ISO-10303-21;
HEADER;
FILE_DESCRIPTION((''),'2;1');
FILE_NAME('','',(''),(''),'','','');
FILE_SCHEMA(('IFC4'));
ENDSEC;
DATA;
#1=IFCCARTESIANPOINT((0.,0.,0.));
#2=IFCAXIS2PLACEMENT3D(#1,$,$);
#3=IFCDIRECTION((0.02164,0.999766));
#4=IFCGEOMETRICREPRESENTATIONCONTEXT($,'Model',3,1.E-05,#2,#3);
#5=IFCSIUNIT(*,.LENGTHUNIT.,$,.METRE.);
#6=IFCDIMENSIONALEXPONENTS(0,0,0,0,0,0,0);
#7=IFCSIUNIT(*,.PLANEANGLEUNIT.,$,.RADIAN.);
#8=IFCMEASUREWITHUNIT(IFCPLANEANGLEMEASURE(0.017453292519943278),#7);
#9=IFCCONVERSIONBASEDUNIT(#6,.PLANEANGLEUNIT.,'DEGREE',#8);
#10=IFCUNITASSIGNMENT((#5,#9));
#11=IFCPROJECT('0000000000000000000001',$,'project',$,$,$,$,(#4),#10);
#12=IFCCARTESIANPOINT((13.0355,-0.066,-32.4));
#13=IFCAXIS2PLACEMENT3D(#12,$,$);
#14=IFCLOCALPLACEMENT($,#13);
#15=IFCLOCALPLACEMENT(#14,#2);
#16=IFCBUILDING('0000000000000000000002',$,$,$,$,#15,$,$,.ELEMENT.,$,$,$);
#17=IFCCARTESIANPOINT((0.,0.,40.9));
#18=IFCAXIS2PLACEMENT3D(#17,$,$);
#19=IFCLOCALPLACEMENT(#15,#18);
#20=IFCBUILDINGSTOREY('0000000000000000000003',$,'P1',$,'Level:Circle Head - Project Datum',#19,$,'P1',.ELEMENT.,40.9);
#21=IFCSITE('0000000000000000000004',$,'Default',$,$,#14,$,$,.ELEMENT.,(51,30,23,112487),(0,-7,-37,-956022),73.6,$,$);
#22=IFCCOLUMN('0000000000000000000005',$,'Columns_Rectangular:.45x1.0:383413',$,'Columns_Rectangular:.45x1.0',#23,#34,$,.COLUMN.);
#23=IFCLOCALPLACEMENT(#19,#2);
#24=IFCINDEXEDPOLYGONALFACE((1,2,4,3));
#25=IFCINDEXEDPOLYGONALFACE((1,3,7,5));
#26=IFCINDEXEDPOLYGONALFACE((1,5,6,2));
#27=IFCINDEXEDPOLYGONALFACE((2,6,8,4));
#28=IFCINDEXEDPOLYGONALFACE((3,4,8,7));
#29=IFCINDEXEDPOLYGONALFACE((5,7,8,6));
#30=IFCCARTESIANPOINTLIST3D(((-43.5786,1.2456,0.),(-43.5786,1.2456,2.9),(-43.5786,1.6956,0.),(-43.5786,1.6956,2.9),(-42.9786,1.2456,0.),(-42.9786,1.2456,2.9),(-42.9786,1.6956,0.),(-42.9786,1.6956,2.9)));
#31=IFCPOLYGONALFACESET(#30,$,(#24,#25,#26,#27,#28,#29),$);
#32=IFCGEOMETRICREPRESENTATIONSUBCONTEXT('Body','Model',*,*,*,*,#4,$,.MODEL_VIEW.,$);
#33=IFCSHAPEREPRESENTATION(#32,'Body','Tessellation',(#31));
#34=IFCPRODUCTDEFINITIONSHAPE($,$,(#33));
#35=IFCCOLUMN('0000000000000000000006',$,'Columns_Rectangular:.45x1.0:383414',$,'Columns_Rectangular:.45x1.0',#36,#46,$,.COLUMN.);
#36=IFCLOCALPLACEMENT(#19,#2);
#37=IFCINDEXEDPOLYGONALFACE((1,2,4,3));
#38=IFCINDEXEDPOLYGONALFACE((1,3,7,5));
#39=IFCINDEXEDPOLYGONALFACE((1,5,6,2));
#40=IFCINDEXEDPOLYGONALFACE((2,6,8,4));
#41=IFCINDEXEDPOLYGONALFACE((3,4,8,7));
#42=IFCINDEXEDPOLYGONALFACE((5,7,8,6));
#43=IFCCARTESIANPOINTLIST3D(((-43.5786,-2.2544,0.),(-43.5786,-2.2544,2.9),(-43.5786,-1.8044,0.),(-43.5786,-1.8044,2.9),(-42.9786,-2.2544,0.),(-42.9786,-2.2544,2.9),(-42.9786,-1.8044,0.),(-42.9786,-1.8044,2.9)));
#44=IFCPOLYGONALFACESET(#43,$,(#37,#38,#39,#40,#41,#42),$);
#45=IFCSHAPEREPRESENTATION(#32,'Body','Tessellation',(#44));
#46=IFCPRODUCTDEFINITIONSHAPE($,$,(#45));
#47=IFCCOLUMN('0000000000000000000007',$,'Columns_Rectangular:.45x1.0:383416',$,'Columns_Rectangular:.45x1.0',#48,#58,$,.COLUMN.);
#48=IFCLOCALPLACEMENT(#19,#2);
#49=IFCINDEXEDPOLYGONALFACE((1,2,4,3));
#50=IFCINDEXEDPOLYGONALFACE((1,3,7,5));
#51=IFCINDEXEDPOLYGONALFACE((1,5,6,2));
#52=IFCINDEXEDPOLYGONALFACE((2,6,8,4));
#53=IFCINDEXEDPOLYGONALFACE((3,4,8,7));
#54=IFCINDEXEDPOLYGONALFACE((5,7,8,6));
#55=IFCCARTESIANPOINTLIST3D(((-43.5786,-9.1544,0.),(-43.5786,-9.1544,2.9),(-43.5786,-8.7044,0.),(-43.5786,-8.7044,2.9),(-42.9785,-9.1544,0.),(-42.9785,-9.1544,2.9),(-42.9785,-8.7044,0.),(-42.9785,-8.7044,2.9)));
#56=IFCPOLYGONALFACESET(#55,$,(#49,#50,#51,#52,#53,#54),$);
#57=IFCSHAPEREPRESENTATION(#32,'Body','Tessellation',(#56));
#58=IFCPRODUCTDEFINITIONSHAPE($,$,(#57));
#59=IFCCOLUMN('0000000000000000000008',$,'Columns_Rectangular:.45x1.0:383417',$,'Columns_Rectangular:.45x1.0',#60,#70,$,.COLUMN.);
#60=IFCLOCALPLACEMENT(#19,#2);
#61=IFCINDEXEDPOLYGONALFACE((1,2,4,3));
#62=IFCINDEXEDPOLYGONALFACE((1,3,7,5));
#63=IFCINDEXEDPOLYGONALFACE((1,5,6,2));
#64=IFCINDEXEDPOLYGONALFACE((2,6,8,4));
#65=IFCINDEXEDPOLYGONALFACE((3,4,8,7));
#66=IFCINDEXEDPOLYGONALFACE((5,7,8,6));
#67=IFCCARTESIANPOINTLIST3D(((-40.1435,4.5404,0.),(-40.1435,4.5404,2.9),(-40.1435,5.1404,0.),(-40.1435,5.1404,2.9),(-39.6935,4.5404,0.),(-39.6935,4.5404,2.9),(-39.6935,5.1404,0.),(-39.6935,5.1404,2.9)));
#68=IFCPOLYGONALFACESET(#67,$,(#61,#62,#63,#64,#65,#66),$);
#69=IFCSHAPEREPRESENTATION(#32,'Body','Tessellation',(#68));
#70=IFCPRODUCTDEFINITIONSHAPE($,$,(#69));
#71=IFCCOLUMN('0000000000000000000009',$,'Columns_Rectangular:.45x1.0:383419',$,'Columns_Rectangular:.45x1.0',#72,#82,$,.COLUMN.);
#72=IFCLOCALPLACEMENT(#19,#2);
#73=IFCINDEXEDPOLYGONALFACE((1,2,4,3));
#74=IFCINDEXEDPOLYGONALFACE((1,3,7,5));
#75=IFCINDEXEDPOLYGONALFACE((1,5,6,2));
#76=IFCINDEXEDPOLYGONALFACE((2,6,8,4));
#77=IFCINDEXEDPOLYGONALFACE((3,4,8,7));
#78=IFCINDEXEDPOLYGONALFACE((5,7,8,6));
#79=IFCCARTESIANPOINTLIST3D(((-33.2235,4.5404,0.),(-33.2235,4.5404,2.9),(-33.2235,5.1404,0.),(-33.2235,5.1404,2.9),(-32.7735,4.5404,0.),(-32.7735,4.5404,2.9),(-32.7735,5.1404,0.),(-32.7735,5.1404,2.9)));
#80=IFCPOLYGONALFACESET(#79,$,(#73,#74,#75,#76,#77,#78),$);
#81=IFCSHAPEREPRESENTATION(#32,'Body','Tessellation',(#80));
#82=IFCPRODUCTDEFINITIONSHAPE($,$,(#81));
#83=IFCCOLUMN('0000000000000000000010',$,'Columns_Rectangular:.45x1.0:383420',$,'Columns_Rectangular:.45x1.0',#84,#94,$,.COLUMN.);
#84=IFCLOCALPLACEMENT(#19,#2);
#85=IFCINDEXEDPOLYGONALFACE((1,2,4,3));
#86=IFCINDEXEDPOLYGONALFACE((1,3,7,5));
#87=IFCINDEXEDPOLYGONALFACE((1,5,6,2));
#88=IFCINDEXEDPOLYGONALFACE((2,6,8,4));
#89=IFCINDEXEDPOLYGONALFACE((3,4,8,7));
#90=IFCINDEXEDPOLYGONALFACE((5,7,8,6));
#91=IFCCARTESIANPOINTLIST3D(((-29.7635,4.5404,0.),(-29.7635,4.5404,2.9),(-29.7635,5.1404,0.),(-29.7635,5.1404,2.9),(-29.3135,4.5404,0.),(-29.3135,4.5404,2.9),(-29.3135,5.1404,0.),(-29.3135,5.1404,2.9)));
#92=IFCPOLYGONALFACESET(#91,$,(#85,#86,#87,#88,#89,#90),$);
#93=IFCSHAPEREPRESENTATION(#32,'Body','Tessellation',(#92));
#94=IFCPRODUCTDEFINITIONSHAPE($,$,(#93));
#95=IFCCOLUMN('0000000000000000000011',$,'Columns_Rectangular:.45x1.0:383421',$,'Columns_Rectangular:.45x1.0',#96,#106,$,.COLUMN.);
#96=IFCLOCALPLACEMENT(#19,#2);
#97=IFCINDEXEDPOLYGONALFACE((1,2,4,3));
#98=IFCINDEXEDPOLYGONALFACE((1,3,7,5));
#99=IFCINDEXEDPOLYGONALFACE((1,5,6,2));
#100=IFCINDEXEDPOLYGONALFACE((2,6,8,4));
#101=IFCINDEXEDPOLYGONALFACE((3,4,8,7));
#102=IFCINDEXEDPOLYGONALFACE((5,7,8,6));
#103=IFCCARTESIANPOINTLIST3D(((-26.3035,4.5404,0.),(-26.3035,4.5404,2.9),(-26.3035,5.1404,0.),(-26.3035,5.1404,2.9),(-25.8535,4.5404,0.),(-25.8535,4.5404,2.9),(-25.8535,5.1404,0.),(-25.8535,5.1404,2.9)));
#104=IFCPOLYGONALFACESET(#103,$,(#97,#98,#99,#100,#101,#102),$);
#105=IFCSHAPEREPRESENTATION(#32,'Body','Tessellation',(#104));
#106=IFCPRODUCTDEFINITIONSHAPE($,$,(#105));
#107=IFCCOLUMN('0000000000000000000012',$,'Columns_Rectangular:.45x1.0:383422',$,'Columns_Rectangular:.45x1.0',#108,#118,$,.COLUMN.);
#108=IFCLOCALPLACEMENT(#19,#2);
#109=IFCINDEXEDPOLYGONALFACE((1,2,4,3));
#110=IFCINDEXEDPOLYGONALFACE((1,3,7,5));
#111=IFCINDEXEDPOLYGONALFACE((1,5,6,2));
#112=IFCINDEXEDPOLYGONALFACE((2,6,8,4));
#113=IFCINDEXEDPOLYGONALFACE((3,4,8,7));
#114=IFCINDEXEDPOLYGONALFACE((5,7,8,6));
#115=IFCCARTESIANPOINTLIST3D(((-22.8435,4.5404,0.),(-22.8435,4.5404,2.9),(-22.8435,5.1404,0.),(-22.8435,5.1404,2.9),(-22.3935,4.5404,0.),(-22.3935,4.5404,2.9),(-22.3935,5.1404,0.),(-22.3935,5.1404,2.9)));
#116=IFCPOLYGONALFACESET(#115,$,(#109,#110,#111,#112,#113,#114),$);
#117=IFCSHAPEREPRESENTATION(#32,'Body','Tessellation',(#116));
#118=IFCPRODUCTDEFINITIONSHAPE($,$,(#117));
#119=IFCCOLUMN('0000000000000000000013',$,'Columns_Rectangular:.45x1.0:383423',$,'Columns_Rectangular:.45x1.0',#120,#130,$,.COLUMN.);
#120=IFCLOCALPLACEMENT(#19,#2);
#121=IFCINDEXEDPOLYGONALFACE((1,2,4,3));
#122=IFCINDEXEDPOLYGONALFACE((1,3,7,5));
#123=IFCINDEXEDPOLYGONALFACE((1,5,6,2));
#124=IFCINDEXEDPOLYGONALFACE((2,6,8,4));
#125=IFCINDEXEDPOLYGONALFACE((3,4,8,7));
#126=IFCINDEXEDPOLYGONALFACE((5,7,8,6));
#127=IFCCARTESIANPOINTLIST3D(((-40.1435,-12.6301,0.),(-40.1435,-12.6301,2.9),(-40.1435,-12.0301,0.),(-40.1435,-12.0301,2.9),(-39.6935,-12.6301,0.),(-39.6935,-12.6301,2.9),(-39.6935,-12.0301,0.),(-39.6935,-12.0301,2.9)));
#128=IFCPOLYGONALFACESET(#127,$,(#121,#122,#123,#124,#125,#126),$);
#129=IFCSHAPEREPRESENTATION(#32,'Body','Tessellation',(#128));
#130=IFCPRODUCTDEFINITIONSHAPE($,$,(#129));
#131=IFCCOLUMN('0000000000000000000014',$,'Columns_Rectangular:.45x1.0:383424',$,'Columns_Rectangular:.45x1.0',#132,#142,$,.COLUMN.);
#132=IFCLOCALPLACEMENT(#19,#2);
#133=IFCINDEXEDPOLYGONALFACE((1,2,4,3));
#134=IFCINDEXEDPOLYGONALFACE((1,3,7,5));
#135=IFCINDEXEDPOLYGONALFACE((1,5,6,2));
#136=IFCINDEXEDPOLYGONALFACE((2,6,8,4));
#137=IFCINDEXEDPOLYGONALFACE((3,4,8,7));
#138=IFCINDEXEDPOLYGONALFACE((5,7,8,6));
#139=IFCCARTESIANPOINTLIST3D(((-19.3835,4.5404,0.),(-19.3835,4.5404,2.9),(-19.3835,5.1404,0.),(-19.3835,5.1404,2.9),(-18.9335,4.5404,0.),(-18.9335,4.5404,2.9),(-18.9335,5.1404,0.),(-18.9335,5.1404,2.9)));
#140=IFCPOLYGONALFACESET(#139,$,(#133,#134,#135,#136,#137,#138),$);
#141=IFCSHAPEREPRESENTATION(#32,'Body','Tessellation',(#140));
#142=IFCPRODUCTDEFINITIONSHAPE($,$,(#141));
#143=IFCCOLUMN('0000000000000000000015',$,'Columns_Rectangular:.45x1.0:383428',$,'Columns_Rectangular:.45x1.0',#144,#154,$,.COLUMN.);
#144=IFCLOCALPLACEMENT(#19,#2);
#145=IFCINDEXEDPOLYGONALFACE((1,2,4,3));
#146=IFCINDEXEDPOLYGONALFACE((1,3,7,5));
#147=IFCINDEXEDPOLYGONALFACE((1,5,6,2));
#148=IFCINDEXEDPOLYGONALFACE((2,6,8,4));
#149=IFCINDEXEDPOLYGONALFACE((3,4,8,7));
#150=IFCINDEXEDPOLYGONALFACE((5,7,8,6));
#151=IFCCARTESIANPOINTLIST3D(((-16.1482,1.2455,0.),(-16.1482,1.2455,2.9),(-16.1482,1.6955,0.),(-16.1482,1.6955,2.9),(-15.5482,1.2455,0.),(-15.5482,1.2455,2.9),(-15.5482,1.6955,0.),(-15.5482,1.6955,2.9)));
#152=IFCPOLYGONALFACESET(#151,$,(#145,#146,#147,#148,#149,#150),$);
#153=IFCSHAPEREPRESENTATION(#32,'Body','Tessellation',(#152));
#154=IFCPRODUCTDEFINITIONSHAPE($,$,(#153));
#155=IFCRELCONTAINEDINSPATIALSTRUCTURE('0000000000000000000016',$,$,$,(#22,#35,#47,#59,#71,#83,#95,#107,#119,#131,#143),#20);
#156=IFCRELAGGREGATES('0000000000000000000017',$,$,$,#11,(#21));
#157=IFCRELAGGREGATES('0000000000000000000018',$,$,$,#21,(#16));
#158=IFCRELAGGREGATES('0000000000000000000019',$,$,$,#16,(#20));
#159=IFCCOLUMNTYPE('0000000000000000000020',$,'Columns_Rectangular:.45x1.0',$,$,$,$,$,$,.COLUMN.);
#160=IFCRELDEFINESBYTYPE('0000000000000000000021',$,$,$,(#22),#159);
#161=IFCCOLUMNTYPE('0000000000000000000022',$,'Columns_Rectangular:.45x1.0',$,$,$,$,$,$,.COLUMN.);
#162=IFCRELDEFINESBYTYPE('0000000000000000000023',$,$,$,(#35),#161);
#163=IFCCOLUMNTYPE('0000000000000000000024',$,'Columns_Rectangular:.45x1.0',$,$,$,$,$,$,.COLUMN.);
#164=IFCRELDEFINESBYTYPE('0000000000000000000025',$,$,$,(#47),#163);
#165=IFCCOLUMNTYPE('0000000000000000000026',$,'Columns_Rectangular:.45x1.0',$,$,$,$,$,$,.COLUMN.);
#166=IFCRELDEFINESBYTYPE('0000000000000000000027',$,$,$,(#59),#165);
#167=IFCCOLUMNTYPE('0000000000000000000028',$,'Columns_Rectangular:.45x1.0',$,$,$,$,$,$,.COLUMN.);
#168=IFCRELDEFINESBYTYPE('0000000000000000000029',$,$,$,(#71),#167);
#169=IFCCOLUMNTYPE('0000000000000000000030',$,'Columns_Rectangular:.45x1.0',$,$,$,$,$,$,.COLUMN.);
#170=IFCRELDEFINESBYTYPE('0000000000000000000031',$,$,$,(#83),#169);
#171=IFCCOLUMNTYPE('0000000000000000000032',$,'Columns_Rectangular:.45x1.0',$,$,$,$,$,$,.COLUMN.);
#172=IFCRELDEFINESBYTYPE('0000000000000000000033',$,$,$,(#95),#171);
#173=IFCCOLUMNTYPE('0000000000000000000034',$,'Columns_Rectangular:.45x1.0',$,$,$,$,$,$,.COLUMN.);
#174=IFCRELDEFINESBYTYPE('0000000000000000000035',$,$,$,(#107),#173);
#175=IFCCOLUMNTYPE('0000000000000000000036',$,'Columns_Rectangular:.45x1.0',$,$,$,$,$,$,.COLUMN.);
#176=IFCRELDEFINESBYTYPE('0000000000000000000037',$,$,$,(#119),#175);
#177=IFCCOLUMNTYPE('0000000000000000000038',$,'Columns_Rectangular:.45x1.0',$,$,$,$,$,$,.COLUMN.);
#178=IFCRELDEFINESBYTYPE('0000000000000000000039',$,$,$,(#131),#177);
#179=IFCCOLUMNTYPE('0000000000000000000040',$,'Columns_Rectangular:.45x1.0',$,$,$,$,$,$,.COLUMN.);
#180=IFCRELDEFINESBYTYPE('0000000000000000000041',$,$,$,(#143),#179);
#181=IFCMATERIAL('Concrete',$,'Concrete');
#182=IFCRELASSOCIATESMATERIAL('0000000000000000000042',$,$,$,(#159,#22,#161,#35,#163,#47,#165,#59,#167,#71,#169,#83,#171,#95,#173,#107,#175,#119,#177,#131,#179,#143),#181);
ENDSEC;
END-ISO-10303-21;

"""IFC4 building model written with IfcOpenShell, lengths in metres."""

from ifc_helpers import new_model, entity, si_unit, converted_unit, direction, frame, origin, place, context, subcontext, project, spatial, indexed_curve, outline, extrude, source, transform, mapped, material, type_object, type_shapes, element, save


model = new_model("IFC4")

# Units and contexts
model_context = context("Model", 3, precision=1e-05, world=origin(), true_north=direction((0.02164, 0.999766)))
body_context = subcontext(model_context, "Body", "Model", "MODEL_VIEW")
ifc_project = project(units=[si_unit("LENGTHUNIT", "METRE"), converted_unit("PLANEANGLEUNIT", "DEGREE", entity("IfcPlaneAngleMeasure", 0.017453292519943278), si_unit("PLANEANGLEUNIT", "RADIAN"), dimensions=[0, 0, 0, 0, 0, 0, 0])], contexts=[model_context])

# Site, building, storey
site_placement = place(None, frame((13.0355, -0.066, -32.4)))
site = spatial("IfcSite", under=ifc_project, at=site_placement, Name="Default", CompositionType="ELEMENT", RefLatitude=(51, 30, 23, 112487), RefLongitude=(0, -7, -37, -956022), RefElevation=73.6)
building_placement = place(site_placement, origin())
building = spatial("IfcBuilding", under=site, at=building_placement, CompositionType="ELEMENT")
storey_placement = place(building_placement, frame((0.0, 0.0, 40.9)))
storey = spatial("IfcBuildingStorey", under=building, at=storey_placement, Name="P1", ObjectType="Level:Circle Head - Project Datum", LongName="P1", CompositionType="ELEMENT", Elevation=40.9)

# Columns
ifc_material = material(Name="Concrete", Category="Concrete")
column_type_1 = type_object("IfcColumnType", Name="Columns_Rectangular:.45x1.0", PredefinedType="COLUMN", material=ifc_material)
shared_shape_1 = source(origin(), body_context, "Body", "SweptSolid", [
    extrude(outline(indexed_curve([(-0.3, -0.225), (0.3, -0.225), (0.3, 0.225), (-0.3, 0.225), (-0.3, -0.225)], self_intersect=False)), frame((-43.2786, 1.4706, 40.9)), (0.0, 0.0, 1.0), 2.9),
])
type_shapes(column_type_1, [shared_shape_1])
column_1_placement = place(storey_placement, frame((0.0, 0.0, -40.9)))
element("IfcColumn", 1, at=column_1_placement, inside=storey, type_object=column_type_1, material=ifc_material, Name="Columns_Rectangular:.45x1.0:383413", ObjectType="Columns_Rectangular:.45x1.0", PredefinedType="COLUMN", context=body_context, shape_type="MappedRepresentation", body=[
    mapped(shared_shape_1, transform((0.0, 0.0, 0.0), scale=1.0)),
])
column_type_2 = type_object("IfcColumnType", Name="Columns_Rectangular:.45x1.0", PredefinedType="COLUMN", material=ifc_material)
shared_shape_2 = source(origin(), body_context, "Body", "SweptSolid", [
    extrude(outline(indexed_curve([(-0.3, -0.225), (0.3, -0.225), (0.3, 0.225), (-0.3, 0.225), (-0.3, -0.225)], self_intersect=False)), frame((-43.2786, -2.0294, 40.9)), (0.0, 0.0, 1.0), 2.9),
])
type_shapes(column_type_2, [shared_shape_2])
column_2_placement = place(storey_placement, frame((0.0, 0.0, -40.9)))
element("IfcColumn", 2, at=column_2_placement, inside=storey, type_object=column_type_2, material=ifc_material, Name="Columns_Rectangular:.45x1.0:383414", ObjectType="Columns_Rectangular:.45x1.0", PredefinedType="COLUMN", context=body_context, shape_type="MappedRepresentation", body=[
    mapped(shared_shape_2, transform((0.0, 0.0, 0.0), scale=1.0)),
])
column_type_3 = type_object("IfcColumnType", Name="Columns_Rectangular:.45x1.0", PredefinedType="COLUMN", material=ifc_material)
shared_shape_3 = source(origin(), body_context, "Body", "SweptSolid", [
    extrude(outline(indexed_curve([(-0.3, -0.225), (0.3, -0.225), (0.3, 0.225), (-0.3, 0.225), (-0.3, -0.225)], self_intersect=False)), frame((-43.2785, -8.9294, 40.9)), (0.0, 0.0, 1.0), 2.9),
])
type_shapes(column_type_3, [shared_shape_3])
column_3_placement = place(storey_placement, frame((0.0, 0.0, -40.9)))
element("IfcColumn", 3, at=column_3_placement, inside=storey, type_object=column_type_3, material=ifc_material, Name="Columns_Rectangular:.45x1.0:383416", ObjectType="Columns_Rectangular:.45x1.0", PredefinedType="COLUMN", context=body_context, shape_type="MappedRepresentation", body=[
    mapped(shared_shape_3, transform((0.0, 0.0, 0.0), scale=1.0)),
])
column_type_4 = type_object("IfcColumnType", Name="Columns_Rectangular:.45x1.0", PredefinedType="COLUMN", material=ifc_material)
shared_shape_4 = source(origin(), body_context, "Body", "SweptSolid", [
    extrude(outline(indexed_curve([(-0.3, -0.225), (0.3, -0.225), (0.3, 0.225), (-0.3, 0.225), (-0.3, -0.225)], self_intersect=False)), frame((-39.9185, 4.8404, 40.9), z_axis=(0.0, 0.0, 1.0), x_axis=(0.0, -1.0, 0.0)), (0.0, 0.0, 1.0), 2.9),
])
type_shapes(column_type_4, [shared_shape_4])
column_4_placement = place(storey_placement, frame((0.0, 0.0, -40.9)))
element("IfcColumn", 4, at=column_4_placement, inside=storey, type_object=column_type_4, material=ifc_material, Name="Columns_Rectangular:.45x1.0:383417", ObjectType="Columns_Rectangular:.45x1.0", PredefinedType="COLUMN", context=body_context, shape_type="MappedRepresentation", body=[
    mapped(shared_shape_4, transform((0.0, 0.0, 0.0), scale=1.0)),
])
column_type_5 = type_object("IfcColumnType", Name="Columns_Rectangular:.45x1.0", PredefinedType="COLUMN", material=ifc_material)
shared_shape_5 = source(origin(), body_context, "Body", "SweptSolid", [
    extrude(outline(indexed_curve([(-0.3, -0.225), (0.3, -0.225), (0.3, 0.225), (-0.3, 0.225), (-0.3, -0.225)], self_intersect=False)), frame((-32.9985, 4.8404, 40.9), z_axis=(0.0, 0.0, 1.0), x_axis=(0.0, -1.0, 0.0)), (0.0, 0.0, 1.0), 2.9),
])
type_shapes(column_type_5, [shared_shape_5])
column_5_placement = place(storey_placement, frame((0.0, 0.0, -40.9)))
element("IfcColumn", 5, at=column_5_placement, inside=storey, type_object=column_type_5, material=ifc_material, Name="Columns_Rectangular:.45x1.0:383419", ObjectType="Columns_Rectangular:.45x1.0", PredefinedType="COLUMN", context=body_context, shape_type="MappedRepresentation", body=[
    mapped(shared_shape_5, transform((0.0, 0.0, 0.0), scale=1.0)),
])
column_type_6 = type_object("IfcColumnType", Name="Columns_Rectangular:.45x1.0", PredefinedType="COLUMN", material=ifc_material)
shared_shape_6 = source(origin(), body_context, "Body", "SweptSolid", [
    extrude(outline(indexed_curve([(-0.3, -0.225), (0.3, -0.225), (0.3, 0.225), (-0.3, 0.225), (-0.3, -0.225)], self_intersect=False)), frame((-29.5385, 4.8404, 40.9), z_axis=(0.0, 0.0, 1.0), x_axis=(0.0, -1.0, 0.0)), (0.0, 0.0, 1.0), 2.9),
])
type_shapes(column_type_6, [shared_shape_6])
column_6_placement = place(storey_placement, frame((0.0, 0.0, -40.9)))
element("IfcColumn", 6, at=column_6_placement, inside=storey, type_object=column_type_6, material=ifc_material, Name="Columns_Rectangular:.45x1.0:383420", ObjectType="Columns_Rectangular:.45x1.0", PredefinedType="COLUMN", context=body_context, shape_type="MappedRepresentation", body=[
    mapped(shared_shape_6, transform((0.0, 0.0, 0.0), scale=1.0)),
])
column_type_7 = type_object("IfcColumnType", Name="Columns_Rectangular:.45x1.0", PredefinedType="COLUMN", material=ifc_material)
shared_shape_7 = source(origin(), body_context, "Body", "SweptSolid", [
    extrude(outline(indexed_curve([(-0.3, -0.225), (0.3, -0.225), (0.3, 0.225), (-0.3, 0.225), (-0.3, -0.225)], self_intersect=False)), frame((-26.0785, 4.8404, 40.9), z_axis=(0.0, 0.0, 1.0), x_axis=(0.0, -1.0, 0.0)), (0.0, 0.0, 1.0), 2.9),
])
type_shapes(column_type_7, [shared_shape_7])
column_7_placement = place(storey_placement, frame((0.0, 0.0, -40.9)))
element("IfcColumn", 7, at=column_7_placement, inside=storey, type_object=column_type_7, material=ifc_material, Name="Columns_Rectangular:.45x1.0:383421", ObjectType="Columns_Rectangular:.45x1.0", PredefinedType="COLUMN", context=body_context, shape_type="MappedRepresentation", body=[
    mapped(shared_shape_7, transform((0.0, 0.0, 0.0), scale=1.0)),
])
column_type_8 = type_object("IfcColumnType", Name="Columns_Rectangular:.45x1.0", PredefinedType="COLUMN", material=ifc_material)
shared_shape_8 = source(origin(), body_context, "Body", "SweptSolid", [
    extrude(outline(indexed_curve([(-0.3, -0.225), (0.3, -0.225), (0.3, 0.225), (-0.3, 0.225), (-0.3, -0.225)], self_intersect=False)), frame((-22.6185, 4.8404, 40.9), z_axis=(0.0, 0.0, 1.0), x_axis=(0.0, -1.0, 0.0)), (0.0, 0.0, 1.0), 2.9),
])
type_shapes(column_type_8, [shared_shape_8])
column_8_placement = place(storey_placement, frame((0.0, 0.0, -40.9)))
element("IfcColumn", 8, at=column_8_placement, inside=storey, type_object=column_type_8, material=ifc_material, Name="Columns_Rectangular:.45x1.0:383422", ObjectType="Columns_Rectangular:.45x1.0", PredefinedType="COLUMN", context=body_context, shape_type="MappedRepresentation", body=[
    mapped(shared_shape_8, transform((0.0, 0.0, 0.0), scale=1.0)),
])
column_type_9 = type_object("IfcColumnType", Name="Columns_Rectangular:.45x1.0", PredefinedType="COLUMN", material=ifc_material)
shared_shape_9 = source(origin(), body_context, "Body", "SweptSolid", [
    extrude(outline(indexed_curve([(-0.3, -0.225), (0.3, -0.225), (0.3, 0.225), (-0.3, 0.225), (-0.3, -0.225)], self_intersect=False)), frame((-39.9185, -12.3301, 40.9), z_axis=(0.0, 0.0, 1.0), x_axis=(0.000011, 1.0, 0.0)), (0.0, 0.0, 1.0), 2.9),
])
type_shapes(column_type_9, [shared_shape_9])
column_9_placement = place(storey_placement, frame((0.0, 0.0, -40.9)))
element("IfcColumn", 9, at=column_9_placement, inside=storey, type_object=column_type_9, material=ifc_material, Name="Columns_Rectangular:.45x1.0:383423", ObjectType="Columns_Rectangular:.45x1.0", PredefinedType="COLUMN", context=body_context, shape_type="MappedRepresentation", body=[
    mapped(shared_shape_9, transform((0.0, 0.0, 0.0), scale=1.0)),
])
column_type_10 = type_object("IfcColumnType", Name="Columns_Rectangular:.45x1.0", PredefinedType="COLUMN", material=ifc_material)
shared_shape_10 = source(origin(), body_context, "Body", "SweptSolid", [
    extrude(outline(indexed_curve([(-0.3, -0.225), (0.3, -0.225), (0.3, 0.225), (-0.3, 0.225), (-0.3, -0.225)], self_intersect=False)), frame((-19.1585, 4.8404, 40.9), z_axis=(0.0, 0.0, 1.0), x_axis=(0.0, -1.0, 0.0)), (0.0, 0.0, 1.0), 2.9),
])
type_shapes(column_type_10, [shared_shape_10])
column_10_placement = place(storey_placement, frame((0.0, 0.0, -40.9)))
element("IfcColumn", 10, at=column_10_placement, inside=storey, type_object=column_type_10, material=ifc_material, Name="Columns_Rectangular:.45x1.0:383424", ObjectType="Columns_Rectangular:.45x1.0", PredefinedType="COLUMN", context=body_context, shape_type="MappedRepresentation", body=[
    mapped(shared_shape_10, transform((0.0, 0.0, 0.0), scale=1.0)),
])
column_type_11 = type_object("IfcColumnType", Name="Columns_Rectangular:.45x1.0", PredefinedType="COLUMN", material=ifc_material)
shared_shape_11 = source(origin(), body_context, "Body", "SweptSolid", [
    extrude(outline(indexed_curve([(-0.3, -0.225), (0.3, -0.225), (0.3, 0.225), (-0.3, 0.225), (-0.3, -0.225)], self_intersect=False)), frame((-15.8482, 1.4705, 40.9), z_axis=(0.0, 0.0, 1.0), x_axis=(-1.0, 0.0, 0.0)), (0.0, 0.0, 1.0), 2.9),
])
type_shapes(column_type_11, [shared_shape_11])
column_11_placement = place(storey_placement, frame((0.0, 0.0, -40.9)))
element("IfcColumn", 11, at=column_11_placement, inside=storey, type_object=column_type_11, material=ifc_material, Name="Columns_Rectangular:.45x1.0:383428", ObjectType="Columns_Rectangular:.45x1.0", PredefinedType="COLUMN", context=body_context, shape_type="MappedRepresentation", body=[
    mapped(shared_shape_11, transform((0.0, 0.0, 0.0), scale=1.0)),
])

save(model, "model.ifc")
